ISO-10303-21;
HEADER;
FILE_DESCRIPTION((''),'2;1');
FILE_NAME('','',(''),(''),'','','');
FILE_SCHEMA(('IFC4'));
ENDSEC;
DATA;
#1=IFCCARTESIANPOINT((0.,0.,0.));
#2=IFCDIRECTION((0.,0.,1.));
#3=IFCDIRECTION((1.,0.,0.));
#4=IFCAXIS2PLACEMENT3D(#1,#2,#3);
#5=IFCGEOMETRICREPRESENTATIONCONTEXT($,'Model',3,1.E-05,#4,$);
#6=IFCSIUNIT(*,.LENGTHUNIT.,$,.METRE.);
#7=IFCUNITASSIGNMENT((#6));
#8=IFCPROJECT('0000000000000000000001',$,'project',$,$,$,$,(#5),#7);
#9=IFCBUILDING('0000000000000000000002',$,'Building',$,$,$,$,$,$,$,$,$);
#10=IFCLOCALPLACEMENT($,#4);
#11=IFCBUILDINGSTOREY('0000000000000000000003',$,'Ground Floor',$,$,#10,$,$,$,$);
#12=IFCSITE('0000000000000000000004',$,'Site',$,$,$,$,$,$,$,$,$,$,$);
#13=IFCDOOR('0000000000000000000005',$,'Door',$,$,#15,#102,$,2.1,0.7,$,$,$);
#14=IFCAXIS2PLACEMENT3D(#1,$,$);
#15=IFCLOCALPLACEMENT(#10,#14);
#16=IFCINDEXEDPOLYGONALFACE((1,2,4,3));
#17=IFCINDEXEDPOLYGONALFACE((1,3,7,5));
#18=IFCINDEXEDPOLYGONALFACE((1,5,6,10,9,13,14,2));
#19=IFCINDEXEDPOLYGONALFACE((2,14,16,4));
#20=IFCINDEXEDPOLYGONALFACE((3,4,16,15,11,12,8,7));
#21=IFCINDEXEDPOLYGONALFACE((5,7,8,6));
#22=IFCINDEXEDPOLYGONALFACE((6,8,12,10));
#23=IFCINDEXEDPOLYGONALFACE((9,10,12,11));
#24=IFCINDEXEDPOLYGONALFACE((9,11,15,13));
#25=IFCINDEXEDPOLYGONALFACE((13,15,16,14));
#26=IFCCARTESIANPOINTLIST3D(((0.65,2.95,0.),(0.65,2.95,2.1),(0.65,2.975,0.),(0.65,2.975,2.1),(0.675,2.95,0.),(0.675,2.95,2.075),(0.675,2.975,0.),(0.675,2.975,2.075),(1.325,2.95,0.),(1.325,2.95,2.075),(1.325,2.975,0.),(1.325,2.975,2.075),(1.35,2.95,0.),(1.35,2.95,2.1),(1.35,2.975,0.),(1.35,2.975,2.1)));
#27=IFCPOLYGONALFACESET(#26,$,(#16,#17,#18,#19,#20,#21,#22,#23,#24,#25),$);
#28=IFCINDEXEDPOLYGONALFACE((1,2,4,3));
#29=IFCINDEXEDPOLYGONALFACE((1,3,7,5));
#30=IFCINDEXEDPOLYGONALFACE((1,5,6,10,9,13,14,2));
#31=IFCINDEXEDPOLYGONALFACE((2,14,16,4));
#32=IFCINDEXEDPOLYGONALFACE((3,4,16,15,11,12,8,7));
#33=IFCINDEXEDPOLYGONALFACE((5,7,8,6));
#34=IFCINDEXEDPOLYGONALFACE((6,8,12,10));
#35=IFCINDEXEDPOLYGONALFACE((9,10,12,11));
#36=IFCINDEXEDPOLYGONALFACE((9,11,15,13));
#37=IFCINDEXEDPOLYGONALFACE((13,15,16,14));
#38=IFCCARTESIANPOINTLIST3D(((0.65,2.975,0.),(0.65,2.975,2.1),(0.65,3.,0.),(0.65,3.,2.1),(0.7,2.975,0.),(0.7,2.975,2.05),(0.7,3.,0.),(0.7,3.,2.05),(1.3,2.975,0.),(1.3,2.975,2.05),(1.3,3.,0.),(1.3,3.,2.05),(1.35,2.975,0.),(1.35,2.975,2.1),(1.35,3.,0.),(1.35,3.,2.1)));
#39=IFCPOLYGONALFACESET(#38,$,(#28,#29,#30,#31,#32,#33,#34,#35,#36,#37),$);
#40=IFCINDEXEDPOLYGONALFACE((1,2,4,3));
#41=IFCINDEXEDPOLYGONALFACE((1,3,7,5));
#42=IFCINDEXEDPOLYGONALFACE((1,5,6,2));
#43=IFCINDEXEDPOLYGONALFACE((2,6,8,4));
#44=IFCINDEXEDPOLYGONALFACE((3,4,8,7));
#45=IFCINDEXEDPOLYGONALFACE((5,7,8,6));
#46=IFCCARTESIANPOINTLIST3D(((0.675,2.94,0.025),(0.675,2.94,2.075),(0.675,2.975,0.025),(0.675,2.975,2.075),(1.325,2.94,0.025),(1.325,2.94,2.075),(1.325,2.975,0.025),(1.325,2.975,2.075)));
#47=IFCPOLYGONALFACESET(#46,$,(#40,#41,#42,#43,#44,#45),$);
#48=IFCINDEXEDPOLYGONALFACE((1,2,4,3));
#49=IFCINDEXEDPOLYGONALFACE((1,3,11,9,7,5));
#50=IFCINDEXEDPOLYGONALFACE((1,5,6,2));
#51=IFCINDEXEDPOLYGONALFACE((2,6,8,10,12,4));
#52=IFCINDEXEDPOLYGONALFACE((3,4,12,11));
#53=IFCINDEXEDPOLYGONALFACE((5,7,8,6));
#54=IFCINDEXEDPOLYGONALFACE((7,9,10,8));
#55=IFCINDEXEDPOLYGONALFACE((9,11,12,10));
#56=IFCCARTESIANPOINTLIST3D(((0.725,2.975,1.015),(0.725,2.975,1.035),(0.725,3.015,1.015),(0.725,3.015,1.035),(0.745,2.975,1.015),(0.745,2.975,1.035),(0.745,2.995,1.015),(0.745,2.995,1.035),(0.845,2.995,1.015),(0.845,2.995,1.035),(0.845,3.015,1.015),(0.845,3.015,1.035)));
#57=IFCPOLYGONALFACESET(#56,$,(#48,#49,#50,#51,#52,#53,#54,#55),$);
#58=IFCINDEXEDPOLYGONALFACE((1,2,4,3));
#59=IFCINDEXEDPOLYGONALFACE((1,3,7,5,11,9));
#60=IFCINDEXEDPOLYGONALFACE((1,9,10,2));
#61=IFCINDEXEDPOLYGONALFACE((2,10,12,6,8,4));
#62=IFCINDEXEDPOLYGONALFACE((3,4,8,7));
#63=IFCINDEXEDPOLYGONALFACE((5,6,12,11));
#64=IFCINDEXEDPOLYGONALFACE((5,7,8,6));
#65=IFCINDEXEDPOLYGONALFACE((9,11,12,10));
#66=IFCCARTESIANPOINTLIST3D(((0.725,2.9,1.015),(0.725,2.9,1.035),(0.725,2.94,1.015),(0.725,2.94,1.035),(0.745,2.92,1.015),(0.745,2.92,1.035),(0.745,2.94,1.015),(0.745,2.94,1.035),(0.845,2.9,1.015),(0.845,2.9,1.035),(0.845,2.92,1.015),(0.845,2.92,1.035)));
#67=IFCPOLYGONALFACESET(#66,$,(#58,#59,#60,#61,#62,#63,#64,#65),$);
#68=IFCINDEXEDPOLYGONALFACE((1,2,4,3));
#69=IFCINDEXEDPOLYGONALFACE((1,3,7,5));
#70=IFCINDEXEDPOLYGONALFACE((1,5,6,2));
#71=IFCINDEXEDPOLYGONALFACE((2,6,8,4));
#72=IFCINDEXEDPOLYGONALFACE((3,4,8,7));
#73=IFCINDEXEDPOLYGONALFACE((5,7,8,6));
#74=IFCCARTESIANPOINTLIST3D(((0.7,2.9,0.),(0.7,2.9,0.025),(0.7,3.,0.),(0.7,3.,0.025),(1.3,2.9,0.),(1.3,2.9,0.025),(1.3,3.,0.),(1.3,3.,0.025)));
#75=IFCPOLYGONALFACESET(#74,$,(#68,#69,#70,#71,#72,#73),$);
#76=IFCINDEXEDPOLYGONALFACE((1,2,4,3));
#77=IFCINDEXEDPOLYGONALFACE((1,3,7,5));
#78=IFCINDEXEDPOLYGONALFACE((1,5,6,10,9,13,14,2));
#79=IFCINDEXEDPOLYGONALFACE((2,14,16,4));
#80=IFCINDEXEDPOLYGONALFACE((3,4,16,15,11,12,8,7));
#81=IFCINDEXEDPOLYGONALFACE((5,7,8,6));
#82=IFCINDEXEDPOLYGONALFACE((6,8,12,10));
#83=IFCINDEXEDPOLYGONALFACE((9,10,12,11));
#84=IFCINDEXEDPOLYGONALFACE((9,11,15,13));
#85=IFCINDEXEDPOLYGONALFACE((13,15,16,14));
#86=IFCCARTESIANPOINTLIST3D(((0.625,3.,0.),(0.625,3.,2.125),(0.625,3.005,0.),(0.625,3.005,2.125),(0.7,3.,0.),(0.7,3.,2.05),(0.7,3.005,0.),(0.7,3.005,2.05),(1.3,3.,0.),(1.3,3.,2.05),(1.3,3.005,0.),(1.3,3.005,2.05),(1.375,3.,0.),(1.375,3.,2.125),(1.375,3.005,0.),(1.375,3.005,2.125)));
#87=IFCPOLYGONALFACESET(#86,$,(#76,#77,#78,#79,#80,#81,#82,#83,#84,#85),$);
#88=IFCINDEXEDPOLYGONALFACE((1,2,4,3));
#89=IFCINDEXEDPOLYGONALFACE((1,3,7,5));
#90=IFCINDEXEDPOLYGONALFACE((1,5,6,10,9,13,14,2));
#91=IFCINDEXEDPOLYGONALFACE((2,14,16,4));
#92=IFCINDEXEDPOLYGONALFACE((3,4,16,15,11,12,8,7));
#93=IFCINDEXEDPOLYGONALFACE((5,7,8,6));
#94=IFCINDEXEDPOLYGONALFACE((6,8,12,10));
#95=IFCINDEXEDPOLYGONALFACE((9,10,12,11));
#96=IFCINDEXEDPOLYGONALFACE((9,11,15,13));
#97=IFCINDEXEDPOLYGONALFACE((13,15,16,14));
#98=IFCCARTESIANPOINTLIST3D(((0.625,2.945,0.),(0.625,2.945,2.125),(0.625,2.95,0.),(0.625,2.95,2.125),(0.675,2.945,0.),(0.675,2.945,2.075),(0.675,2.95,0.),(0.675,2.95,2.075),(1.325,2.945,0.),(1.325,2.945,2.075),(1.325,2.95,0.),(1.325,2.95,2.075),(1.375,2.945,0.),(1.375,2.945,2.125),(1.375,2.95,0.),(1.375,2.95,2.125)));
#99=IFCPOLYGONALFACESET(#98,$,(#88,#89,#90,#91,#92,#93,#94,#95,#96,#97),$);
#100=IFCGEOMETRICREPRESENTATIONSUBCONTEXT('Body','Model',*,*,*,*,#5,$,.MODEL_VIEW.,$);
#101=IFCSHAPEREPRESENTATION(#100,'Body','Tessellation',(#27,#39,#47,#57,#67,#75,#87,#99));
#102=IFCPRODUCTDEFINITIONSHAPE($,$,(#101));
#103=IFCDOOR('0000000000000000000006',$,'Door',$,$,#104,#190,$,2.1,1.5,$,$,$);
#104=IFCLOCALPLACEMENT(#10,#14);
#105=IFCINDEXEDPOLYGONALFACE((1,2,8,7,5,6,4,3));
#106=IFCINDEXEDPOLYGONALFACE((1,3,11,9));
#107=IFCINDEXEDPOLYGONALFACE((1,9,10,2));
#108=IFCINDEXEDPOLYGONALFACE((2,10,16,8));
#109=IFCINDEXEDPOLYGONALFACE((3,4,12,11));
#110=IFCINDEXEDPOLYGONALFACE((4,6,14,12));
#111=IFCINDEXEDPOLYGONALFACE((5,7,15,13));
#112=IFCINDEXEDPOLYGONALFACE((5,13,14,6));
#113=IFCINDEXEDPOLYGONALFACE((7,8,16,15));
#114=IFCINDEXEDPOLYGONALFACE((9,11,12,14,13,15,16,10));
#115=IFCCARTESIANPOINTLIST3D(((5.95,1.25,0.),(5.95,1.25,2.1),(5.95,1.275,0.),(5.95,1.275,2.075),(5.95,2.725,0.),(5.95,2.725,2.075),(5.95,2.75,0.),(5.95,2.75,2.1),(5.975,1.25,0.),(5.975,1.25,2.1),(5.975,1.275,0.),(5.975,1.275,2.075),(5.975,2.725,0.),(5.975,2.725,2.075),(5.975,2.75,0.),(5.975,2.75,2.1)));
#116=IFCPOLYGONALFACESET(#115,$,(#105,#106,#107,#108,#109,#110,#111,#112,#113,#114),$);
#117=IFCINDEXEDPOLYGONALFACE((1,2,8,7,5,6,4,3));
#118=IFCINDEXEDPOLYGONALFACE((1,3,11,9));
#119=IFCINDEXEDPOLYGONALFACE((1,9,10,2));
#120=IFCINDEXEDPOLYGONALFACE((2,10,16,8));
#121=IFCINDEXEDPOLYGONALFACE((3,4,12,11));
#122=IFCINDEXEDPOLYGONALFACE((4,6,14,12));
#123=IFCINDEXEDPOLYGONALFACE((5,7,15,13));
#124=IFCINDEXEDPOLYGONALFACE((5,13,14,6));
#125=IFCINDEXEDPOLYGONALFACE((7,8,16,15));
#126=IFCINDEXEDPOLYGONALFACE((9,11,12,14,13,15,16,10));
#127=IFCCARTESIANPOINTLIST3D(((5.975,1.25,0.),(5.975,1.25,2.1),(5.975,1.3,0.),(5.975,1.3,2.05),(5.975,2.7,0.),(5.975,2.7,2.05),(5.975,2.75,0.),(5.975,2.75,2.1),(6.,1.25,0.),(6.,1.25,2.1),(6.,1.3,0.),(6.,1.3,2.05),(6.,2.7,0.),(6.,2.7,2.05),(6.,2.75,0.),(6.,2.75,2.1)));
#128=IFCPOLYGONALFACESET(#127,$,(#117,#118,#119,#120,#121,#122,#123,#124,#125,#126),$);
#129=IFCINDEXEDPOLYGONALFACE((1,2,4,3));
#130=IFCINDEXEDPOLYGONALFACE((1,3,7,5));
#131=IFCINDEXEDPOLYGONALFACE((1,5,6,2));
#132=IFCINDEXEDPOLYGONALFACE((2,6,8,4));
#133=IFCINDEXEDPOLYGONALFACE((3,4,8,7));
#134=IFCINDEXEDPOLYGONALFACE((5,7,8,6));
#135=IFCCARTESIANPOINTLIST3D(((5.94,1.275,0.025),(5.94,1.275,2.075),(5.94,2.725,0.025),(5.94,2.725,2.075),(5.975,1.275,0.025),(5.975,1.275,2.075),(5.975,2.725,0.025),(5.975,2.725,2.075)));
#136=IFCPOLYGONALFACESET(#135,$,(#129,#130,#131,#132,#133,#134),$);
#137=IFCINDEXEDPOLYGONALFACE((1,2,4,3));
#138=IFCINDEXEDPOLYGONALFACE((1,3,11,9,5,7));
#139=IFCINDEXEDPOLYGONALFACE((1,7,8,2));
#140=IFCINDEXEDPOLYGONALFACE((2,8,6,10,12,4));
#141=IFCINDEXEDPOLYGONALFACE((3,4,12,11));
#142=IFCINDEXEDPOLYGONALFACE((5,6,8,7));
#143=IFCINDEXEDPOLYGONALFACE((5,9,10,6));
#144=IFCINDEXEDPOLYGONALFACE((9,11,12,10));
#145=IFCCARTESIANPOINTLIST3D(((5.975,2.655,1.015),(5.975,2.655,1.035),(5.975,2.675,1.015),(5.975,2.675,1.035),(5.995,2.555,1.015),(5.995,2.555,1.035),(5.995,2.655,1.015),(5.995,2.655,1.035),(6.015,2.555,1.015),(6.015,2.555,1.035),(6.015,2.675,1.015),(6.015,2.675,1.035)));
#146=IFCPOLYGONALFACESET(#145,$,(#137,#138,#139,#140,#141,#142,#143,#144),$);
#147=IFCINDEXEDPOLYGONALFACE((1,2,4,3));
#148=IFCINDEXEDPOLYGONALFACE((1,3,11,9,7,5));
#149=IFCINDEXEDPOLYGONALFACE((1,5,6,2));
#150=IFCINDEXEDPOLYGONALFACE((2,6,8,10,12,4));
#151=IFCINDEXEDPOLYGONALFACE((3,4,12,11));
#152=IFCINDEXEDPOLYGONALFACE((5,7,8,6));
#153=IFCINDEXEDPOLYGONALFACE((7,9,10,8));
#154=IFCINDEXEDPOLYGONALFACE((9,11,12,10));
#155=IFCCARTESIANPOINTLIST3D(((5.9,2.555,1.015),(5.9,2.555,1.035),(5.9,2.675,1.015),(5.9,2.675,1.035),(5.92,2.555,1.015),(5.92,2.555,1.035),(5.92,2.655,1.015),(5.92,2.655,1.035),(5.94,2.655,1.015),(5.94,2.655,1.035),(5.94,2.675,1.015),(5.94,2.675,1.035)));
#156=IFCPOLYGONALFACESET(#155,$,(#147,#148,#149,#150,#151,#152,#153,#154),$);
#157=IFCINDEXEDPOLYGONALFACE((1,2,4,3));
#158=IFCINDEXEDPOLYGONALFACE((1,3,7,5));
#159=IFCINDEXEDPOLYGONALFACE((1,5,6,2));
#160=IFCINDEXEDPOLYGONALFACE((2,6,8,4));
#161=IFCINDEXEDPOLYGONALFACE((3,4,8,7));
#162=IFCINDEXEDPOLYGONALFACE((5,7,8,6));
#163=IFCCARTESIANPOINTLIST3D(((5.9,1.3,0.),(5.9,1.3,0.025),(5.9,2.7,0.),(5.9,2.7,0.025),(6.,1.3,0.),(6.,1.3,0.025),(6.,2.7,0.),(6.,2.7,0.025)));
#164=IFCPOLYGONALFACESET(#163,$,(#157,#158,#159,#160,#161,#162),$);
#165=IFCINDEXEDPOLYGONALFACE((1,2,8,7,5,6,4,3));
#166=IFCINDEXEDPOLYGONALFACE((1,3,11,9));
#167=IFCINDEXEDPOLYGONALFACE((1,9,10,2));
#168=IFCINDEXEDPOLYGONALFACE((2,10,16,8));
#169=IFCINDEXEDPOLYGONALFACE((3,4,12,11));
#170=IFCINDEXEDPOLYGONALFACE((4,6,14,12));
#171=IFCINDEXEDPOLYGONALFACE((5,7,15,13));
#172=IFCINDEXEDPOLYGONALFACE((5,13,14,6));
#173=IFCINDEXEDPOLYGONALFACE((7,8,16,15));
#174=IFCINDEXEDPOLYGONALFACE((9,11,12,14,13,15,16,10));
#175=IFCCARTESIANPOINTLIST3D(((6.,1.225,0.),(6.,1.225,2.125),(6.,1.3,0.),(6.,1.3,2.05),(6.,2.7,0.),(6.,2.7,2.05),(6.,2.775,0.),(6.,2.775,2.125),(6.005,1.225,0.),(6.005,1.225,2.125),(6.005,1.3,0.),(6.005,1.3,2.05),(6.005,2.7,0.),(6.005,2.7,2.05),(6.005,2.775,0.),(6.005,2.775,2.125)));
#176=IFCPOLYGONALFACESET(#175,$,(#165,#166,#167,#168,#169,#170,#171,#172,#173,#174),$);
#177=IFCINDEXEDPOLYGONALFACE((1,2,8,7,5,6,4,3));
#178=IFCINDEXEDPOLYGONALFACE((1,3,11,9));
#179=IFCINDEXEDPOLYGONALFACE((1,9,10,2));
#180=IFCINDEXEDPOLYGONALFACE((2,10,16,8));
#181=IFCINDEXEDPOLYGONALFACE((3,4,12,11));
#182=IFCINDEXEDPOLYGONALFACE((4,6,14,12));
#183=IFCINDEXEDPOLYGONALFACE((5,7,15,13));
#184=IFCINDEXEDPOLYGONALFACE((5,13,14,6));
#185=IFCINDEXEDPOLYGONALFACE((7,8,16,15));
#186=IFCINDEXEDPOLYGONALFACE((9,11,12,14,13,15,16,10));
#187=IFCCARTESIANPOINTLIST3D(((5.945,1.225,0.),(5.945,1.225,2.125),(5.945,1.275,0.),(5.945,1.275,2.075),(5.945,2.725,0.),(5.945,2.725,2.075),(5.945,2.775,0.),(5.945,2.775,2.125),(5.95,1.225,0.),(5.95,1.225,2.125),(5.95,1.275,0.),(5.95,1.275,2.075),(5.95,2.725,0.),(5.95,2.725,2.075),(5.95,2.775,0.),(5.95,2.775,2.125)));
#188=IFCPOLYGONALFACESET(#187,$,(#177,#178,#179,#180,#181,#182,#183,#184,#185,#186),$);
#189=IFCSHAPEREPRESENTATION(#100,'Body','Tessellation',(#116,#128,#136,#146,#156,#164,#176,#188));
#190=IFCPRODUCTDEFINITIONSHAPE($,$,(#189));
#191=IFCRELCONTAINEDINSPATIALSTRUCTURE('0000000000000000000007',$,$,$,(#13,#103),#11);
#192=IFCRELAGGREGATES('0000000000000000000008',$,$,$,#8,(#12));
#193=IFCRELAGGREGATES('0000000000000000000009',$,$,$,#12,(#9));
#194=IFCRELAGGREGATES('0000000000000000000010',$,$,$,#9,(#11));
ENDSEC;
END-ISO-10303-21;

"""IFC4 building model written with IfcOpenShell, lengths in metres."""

from ifc_helpers import new_model, si_unit, frame, origin_with_axes, place, context, subcontext, project, spatial, line, indexed_curve, outline, extrude, element, save


model = new_model("IFC4")

# Units and contexts
model_context = context("Model", 3, precision=1e-05, world=origin_with_axes())
body_context = subcontext(model_context, "Body", "Model", "MODEL_VIEW")
ifc_project = project(units=[si_unit("LENGTHUNIT", "METRE")], contexts=[model_context])

# Site, building, storey
site = spatial("IfcSite", under=ifc_project, Name="Site")
building = spatial("IfcBuilding", under=site, Name="Building")
storey_placement = place(None, origin_with_axes())
storey = spatial("IfcBuildingStorey", under=building, at=storey_placement, Name="Ground Floor")

# Doors
door_1_placement = place(storey_placement, frame((1.35, 3.0, 0.0), z_axis=(0.0, 0.0, 1.0), x_axis=(-1.0, 0.0, 0.0)))
element("IfcDoor", 1, at=door_1_placement, inside=storey, Name="Door", OverallHeight=2.1, OverallWidth=0.7, context=body_context, shape_type="SweptSolid", body=[
    extrude(outline(indexed_curve([(0.0, 0.0), (0.0, 2.1), (0.7, 2.1), (0.7, 0.0), (0.675, 0.0), (0.675, 2.075), (0.025, 2.075), (0.025, 0.0)], segments=[line(1, 2, 3, 4, 5, 6, 7, 8, 1)])), frame((0.0, 0.025, 0.0), z_axis=(0.0, -1.0, 0.0), x_axis=(1.0, 0.0, 0.0)), (0.0, 0.0, -1.0), 0.025),
    extrude(outline(indexed_curve([(0.0, 0.0), (0.0, 2.1), (0.7, 2.1), (0.7, 0.0), (0.65, 0.0), (0.65, 2.05), (0.05, 2.05), (0.05, 0.0)], segments=[line(1, 2, 3, 4, 5, 6, 7, 8, 1)])), frame((0.0, 0.0, 0.0), z_axis=(0.0, -1.0, 0.0), x_axis=(1.0, 0.0, 0.0)), (0.0, 0.0, -1.0), 0.025),
    extrude(outline(indexed_curve([(0.0, 0.0), (0.65, 0.0), (0.65, 0.035), (0.0, 0.035)], segments=[line(1, 2, 3, 4, 1)])), frame((0.025, 0.025, 0.025), z_axis=(0.0, 0.0, 1.0), x_axis=(1.0, 0.0, 0.0)), (0.0, 0.0, 1.0), 2.05),
    extrude(outline(indexed_curve([(0.0, 0.0), (0.0, -0.04), (-0.12, -0.04), (-0.12, -0.02), (-0.02, -0.02), (-0.02, 0.0)], segments=[line(1, 2, 3, 4, 5, 6, 1)])), frame((0.625, 0.025, 1.015), z_axis=(0.0, 0.0, 1.0), x_axis=(1.0, 0.0, 0.0)), (0.0, 0.0, 1.0), 0.02),
    extrude(outline(indexed_curve([(0.0, 0.0), (0.0, 0.04), (-0.12, 0.04), (-0.12, 0.02), (-0.02, 0.02), (-0.02, 0.0)], segments=[line(1, 2, 3, 4, 5, 6, 1)])), frame((0.625, 0.06, 1.015), z_axis=(0.0, 0.0, 1.0), x_axis=(1.0, 0.0, 0.0)), (0.0, 0.0, 1.0), 0.02),
    extrude(outline(indexed_curve([(0.0, 0.0), (0.6, 0.0), (0.6, 0.1), (0.0, 0.1)], segments=[line(1, 2, 3, 4, 1)])), frame((0.05, 0.0, 0.0), z_axis=(0.0, 0.0, 1.0), x_axis=(1.0, 0.0, 0.0)), (0.0, 0.0, 1.0), 0.025),
    extrude(outline(indexed_curve([(0.0, 0.0), (0.0, 2.125), (0.75, 2.125), (0.75, 0.0), (0.675, 0.0), (0.675, 2.05), (0.075, 2.05), (0.075, 0.0)], segments=[line(1, 2, 3, 4, 5, 6, 7, 8, 1)])), frame((-0.025, -0.005, 0.0), z_axis=(0.0, -1.0, 0.0), x_axis=(1.0, 0.0, 0.0)), (0.0, 0.0, -1.0), 0.005),
    extrude(outline(indexed_curve([(0.0, 0.0), (0.0, 2.125), (0.75, 2.125), (0.75, 0.0), (0.7, 0.0), (0.7, 2.075), (0.05, 2.075), (0.05, 0.0)], segments=[line(1, 2, 3, 4, 5, 6, 7, 8, 1)])), frame((-0.025, 0.05, 0.0), z_axis=(0.0, -1.0, 0.0), x_axis=(1.0, 0.0, 0.0)), (0.0, 0.0, -1.0), 0.005),
])
door_2_placement = place(storey_placement, frame((6.0, 1.25, 0.0), z_axis=(0.0, 0.0, 1.0), x_axis=(0.0, 1.0, 0.0)))
element("IfcDoor", 2, at=door_2_placement, inside=storey, Name="Door", OverallHeight=2.1, OverallWidth=1.5, context=body_context, shape_type="SweptSolid", body=[
    extrude(outline(indexed_curve([(0.0, 0.0), (0.0, 2.1), (1.5, 2.1), (1.5, 0.0), (1.475, 0.0), (1.475, 2.075), (0.025, 2.075), (0.025, 0.0)], segments=[line(1, 2, 3, 4, 5, 6, 7, 8, 1)])), frame((0.0, 0.025, 0.0), z_axis=(0.0, -1.0, 0.0), x_axis=(1.0, 0.0, 0.0)), (0.0, 0.0, -1.0), 0.025),
    extrude(outline(indexed_curve([(0.0, 0.0), (0.0, 2.1), (1.5, 2.1), (1.5, 0.0), (1.45, 0.0), (1.45, 2.05), (0.05, 2.05), (0.05, 0.0)], segments=[line(1, 2, 3, 4, 5, 6, 7, 8, 1)])), frame((0.0, 0.0, 0.0), z_axis=(0.0, -1.0, 0.0), x_axis=(1.0, 0.0, 0.0)), (0.0, 0.0, -1.0), 0.025),
    extrude(outline(indexed_curve([(0.0, 0.0), (1.45, 0.0), (1.45, 0.035), (0.0, 0.035)], segments=[line(1, 2, 3, 4, 1)])), frame((0.025, 0.025, 0.025), z_axis=(0.0, 0.0, 1.0), x_axis=(1.0, 0.0, 0.0)), (0.0, 0.0, 1.0), 2.05),
    extrude(outline(indexed_curve([(0.0, 0.0), (0.0, -0.04), (-0.12, -0.04), (-0.12, -0.02), (-0.02, -0.02), (-0.02, 0.0)], segments=[line(1, 2, 3, 4, 5, 6, 1)])), frame((1.425, 0.025, 1.015), z_axis=(0.0, 0.0, 1.0), x_axis=(1.0, 0.0, 0.0)), (0.0, 0.0, 1.0), 0.02),
    extrude(outline(indexed_curve([(0.0, 0.0), (0.0, 0.04), (-0.12, 0.04), (-0.12, 0.02), (-0.02, 0.02), (-0.02, 0.0)], segments=[line(1, 2, 3, 4, 5, 6, 1)])), frame((1.425, 0.06, 1.015), z_axis=(0.0, 0.0, 1.0), x_axis=(1.0, 0.0, 0.0)), (0.0, 0.0, 1.0), 0.02),
    extrude(outline(indexed_curve([(0.0, 0.0), (1.4, 0.0), (1.4, 0.1), (0.0, 0.1)], segments=[line(1, 2, 3, 4, 1)])), frame((0.05, 0.0, 0.0), z_axis=(0.0, 0.0, 1.0), x_axis=(1.0, 0.0, 0.0)), (0.0, 0.0, 1.0), 0.025),
    extrude(outline(indexed_curve([(0.0, 0.0), (0.0, 2.125), (1.55, 2.125), (1.55, 0.0), (1.475, 0.0), (1.475, 2.05), (0.075, 2.05), (0.075, 0.0)], segments=[line(1, 2, 3, 4, 5, 6, 7, 8, 1)])), frame((-0.025, -0.005, 0.0), z_axis=(0.0, -1.0, 0.0), x_axis=(1.0, 0.0, 0.0)), (0.0, 0.0, -1.0), 0.005),
    extrude(outline(indexed_curve([(0.0, 0.0), (0.0, 2.125), (1.55, 2.125), (1.55, 0.0), (1.5, 0.0), (1.5, 2.075), (0.05, 2.075), (0.05, 0.0)], segments=[line(1, 2, 3, 4, 5, 6, 7, 8, 1)])), frame((-0.025, 0.05, 0.0), z_axis=(0.0, -1.0, 0.0), x_axis=(1.0, 0.0, 0.0)), (0.0, 0.0, -1.0), 0.005),
])

save(model, "model.ifc")
